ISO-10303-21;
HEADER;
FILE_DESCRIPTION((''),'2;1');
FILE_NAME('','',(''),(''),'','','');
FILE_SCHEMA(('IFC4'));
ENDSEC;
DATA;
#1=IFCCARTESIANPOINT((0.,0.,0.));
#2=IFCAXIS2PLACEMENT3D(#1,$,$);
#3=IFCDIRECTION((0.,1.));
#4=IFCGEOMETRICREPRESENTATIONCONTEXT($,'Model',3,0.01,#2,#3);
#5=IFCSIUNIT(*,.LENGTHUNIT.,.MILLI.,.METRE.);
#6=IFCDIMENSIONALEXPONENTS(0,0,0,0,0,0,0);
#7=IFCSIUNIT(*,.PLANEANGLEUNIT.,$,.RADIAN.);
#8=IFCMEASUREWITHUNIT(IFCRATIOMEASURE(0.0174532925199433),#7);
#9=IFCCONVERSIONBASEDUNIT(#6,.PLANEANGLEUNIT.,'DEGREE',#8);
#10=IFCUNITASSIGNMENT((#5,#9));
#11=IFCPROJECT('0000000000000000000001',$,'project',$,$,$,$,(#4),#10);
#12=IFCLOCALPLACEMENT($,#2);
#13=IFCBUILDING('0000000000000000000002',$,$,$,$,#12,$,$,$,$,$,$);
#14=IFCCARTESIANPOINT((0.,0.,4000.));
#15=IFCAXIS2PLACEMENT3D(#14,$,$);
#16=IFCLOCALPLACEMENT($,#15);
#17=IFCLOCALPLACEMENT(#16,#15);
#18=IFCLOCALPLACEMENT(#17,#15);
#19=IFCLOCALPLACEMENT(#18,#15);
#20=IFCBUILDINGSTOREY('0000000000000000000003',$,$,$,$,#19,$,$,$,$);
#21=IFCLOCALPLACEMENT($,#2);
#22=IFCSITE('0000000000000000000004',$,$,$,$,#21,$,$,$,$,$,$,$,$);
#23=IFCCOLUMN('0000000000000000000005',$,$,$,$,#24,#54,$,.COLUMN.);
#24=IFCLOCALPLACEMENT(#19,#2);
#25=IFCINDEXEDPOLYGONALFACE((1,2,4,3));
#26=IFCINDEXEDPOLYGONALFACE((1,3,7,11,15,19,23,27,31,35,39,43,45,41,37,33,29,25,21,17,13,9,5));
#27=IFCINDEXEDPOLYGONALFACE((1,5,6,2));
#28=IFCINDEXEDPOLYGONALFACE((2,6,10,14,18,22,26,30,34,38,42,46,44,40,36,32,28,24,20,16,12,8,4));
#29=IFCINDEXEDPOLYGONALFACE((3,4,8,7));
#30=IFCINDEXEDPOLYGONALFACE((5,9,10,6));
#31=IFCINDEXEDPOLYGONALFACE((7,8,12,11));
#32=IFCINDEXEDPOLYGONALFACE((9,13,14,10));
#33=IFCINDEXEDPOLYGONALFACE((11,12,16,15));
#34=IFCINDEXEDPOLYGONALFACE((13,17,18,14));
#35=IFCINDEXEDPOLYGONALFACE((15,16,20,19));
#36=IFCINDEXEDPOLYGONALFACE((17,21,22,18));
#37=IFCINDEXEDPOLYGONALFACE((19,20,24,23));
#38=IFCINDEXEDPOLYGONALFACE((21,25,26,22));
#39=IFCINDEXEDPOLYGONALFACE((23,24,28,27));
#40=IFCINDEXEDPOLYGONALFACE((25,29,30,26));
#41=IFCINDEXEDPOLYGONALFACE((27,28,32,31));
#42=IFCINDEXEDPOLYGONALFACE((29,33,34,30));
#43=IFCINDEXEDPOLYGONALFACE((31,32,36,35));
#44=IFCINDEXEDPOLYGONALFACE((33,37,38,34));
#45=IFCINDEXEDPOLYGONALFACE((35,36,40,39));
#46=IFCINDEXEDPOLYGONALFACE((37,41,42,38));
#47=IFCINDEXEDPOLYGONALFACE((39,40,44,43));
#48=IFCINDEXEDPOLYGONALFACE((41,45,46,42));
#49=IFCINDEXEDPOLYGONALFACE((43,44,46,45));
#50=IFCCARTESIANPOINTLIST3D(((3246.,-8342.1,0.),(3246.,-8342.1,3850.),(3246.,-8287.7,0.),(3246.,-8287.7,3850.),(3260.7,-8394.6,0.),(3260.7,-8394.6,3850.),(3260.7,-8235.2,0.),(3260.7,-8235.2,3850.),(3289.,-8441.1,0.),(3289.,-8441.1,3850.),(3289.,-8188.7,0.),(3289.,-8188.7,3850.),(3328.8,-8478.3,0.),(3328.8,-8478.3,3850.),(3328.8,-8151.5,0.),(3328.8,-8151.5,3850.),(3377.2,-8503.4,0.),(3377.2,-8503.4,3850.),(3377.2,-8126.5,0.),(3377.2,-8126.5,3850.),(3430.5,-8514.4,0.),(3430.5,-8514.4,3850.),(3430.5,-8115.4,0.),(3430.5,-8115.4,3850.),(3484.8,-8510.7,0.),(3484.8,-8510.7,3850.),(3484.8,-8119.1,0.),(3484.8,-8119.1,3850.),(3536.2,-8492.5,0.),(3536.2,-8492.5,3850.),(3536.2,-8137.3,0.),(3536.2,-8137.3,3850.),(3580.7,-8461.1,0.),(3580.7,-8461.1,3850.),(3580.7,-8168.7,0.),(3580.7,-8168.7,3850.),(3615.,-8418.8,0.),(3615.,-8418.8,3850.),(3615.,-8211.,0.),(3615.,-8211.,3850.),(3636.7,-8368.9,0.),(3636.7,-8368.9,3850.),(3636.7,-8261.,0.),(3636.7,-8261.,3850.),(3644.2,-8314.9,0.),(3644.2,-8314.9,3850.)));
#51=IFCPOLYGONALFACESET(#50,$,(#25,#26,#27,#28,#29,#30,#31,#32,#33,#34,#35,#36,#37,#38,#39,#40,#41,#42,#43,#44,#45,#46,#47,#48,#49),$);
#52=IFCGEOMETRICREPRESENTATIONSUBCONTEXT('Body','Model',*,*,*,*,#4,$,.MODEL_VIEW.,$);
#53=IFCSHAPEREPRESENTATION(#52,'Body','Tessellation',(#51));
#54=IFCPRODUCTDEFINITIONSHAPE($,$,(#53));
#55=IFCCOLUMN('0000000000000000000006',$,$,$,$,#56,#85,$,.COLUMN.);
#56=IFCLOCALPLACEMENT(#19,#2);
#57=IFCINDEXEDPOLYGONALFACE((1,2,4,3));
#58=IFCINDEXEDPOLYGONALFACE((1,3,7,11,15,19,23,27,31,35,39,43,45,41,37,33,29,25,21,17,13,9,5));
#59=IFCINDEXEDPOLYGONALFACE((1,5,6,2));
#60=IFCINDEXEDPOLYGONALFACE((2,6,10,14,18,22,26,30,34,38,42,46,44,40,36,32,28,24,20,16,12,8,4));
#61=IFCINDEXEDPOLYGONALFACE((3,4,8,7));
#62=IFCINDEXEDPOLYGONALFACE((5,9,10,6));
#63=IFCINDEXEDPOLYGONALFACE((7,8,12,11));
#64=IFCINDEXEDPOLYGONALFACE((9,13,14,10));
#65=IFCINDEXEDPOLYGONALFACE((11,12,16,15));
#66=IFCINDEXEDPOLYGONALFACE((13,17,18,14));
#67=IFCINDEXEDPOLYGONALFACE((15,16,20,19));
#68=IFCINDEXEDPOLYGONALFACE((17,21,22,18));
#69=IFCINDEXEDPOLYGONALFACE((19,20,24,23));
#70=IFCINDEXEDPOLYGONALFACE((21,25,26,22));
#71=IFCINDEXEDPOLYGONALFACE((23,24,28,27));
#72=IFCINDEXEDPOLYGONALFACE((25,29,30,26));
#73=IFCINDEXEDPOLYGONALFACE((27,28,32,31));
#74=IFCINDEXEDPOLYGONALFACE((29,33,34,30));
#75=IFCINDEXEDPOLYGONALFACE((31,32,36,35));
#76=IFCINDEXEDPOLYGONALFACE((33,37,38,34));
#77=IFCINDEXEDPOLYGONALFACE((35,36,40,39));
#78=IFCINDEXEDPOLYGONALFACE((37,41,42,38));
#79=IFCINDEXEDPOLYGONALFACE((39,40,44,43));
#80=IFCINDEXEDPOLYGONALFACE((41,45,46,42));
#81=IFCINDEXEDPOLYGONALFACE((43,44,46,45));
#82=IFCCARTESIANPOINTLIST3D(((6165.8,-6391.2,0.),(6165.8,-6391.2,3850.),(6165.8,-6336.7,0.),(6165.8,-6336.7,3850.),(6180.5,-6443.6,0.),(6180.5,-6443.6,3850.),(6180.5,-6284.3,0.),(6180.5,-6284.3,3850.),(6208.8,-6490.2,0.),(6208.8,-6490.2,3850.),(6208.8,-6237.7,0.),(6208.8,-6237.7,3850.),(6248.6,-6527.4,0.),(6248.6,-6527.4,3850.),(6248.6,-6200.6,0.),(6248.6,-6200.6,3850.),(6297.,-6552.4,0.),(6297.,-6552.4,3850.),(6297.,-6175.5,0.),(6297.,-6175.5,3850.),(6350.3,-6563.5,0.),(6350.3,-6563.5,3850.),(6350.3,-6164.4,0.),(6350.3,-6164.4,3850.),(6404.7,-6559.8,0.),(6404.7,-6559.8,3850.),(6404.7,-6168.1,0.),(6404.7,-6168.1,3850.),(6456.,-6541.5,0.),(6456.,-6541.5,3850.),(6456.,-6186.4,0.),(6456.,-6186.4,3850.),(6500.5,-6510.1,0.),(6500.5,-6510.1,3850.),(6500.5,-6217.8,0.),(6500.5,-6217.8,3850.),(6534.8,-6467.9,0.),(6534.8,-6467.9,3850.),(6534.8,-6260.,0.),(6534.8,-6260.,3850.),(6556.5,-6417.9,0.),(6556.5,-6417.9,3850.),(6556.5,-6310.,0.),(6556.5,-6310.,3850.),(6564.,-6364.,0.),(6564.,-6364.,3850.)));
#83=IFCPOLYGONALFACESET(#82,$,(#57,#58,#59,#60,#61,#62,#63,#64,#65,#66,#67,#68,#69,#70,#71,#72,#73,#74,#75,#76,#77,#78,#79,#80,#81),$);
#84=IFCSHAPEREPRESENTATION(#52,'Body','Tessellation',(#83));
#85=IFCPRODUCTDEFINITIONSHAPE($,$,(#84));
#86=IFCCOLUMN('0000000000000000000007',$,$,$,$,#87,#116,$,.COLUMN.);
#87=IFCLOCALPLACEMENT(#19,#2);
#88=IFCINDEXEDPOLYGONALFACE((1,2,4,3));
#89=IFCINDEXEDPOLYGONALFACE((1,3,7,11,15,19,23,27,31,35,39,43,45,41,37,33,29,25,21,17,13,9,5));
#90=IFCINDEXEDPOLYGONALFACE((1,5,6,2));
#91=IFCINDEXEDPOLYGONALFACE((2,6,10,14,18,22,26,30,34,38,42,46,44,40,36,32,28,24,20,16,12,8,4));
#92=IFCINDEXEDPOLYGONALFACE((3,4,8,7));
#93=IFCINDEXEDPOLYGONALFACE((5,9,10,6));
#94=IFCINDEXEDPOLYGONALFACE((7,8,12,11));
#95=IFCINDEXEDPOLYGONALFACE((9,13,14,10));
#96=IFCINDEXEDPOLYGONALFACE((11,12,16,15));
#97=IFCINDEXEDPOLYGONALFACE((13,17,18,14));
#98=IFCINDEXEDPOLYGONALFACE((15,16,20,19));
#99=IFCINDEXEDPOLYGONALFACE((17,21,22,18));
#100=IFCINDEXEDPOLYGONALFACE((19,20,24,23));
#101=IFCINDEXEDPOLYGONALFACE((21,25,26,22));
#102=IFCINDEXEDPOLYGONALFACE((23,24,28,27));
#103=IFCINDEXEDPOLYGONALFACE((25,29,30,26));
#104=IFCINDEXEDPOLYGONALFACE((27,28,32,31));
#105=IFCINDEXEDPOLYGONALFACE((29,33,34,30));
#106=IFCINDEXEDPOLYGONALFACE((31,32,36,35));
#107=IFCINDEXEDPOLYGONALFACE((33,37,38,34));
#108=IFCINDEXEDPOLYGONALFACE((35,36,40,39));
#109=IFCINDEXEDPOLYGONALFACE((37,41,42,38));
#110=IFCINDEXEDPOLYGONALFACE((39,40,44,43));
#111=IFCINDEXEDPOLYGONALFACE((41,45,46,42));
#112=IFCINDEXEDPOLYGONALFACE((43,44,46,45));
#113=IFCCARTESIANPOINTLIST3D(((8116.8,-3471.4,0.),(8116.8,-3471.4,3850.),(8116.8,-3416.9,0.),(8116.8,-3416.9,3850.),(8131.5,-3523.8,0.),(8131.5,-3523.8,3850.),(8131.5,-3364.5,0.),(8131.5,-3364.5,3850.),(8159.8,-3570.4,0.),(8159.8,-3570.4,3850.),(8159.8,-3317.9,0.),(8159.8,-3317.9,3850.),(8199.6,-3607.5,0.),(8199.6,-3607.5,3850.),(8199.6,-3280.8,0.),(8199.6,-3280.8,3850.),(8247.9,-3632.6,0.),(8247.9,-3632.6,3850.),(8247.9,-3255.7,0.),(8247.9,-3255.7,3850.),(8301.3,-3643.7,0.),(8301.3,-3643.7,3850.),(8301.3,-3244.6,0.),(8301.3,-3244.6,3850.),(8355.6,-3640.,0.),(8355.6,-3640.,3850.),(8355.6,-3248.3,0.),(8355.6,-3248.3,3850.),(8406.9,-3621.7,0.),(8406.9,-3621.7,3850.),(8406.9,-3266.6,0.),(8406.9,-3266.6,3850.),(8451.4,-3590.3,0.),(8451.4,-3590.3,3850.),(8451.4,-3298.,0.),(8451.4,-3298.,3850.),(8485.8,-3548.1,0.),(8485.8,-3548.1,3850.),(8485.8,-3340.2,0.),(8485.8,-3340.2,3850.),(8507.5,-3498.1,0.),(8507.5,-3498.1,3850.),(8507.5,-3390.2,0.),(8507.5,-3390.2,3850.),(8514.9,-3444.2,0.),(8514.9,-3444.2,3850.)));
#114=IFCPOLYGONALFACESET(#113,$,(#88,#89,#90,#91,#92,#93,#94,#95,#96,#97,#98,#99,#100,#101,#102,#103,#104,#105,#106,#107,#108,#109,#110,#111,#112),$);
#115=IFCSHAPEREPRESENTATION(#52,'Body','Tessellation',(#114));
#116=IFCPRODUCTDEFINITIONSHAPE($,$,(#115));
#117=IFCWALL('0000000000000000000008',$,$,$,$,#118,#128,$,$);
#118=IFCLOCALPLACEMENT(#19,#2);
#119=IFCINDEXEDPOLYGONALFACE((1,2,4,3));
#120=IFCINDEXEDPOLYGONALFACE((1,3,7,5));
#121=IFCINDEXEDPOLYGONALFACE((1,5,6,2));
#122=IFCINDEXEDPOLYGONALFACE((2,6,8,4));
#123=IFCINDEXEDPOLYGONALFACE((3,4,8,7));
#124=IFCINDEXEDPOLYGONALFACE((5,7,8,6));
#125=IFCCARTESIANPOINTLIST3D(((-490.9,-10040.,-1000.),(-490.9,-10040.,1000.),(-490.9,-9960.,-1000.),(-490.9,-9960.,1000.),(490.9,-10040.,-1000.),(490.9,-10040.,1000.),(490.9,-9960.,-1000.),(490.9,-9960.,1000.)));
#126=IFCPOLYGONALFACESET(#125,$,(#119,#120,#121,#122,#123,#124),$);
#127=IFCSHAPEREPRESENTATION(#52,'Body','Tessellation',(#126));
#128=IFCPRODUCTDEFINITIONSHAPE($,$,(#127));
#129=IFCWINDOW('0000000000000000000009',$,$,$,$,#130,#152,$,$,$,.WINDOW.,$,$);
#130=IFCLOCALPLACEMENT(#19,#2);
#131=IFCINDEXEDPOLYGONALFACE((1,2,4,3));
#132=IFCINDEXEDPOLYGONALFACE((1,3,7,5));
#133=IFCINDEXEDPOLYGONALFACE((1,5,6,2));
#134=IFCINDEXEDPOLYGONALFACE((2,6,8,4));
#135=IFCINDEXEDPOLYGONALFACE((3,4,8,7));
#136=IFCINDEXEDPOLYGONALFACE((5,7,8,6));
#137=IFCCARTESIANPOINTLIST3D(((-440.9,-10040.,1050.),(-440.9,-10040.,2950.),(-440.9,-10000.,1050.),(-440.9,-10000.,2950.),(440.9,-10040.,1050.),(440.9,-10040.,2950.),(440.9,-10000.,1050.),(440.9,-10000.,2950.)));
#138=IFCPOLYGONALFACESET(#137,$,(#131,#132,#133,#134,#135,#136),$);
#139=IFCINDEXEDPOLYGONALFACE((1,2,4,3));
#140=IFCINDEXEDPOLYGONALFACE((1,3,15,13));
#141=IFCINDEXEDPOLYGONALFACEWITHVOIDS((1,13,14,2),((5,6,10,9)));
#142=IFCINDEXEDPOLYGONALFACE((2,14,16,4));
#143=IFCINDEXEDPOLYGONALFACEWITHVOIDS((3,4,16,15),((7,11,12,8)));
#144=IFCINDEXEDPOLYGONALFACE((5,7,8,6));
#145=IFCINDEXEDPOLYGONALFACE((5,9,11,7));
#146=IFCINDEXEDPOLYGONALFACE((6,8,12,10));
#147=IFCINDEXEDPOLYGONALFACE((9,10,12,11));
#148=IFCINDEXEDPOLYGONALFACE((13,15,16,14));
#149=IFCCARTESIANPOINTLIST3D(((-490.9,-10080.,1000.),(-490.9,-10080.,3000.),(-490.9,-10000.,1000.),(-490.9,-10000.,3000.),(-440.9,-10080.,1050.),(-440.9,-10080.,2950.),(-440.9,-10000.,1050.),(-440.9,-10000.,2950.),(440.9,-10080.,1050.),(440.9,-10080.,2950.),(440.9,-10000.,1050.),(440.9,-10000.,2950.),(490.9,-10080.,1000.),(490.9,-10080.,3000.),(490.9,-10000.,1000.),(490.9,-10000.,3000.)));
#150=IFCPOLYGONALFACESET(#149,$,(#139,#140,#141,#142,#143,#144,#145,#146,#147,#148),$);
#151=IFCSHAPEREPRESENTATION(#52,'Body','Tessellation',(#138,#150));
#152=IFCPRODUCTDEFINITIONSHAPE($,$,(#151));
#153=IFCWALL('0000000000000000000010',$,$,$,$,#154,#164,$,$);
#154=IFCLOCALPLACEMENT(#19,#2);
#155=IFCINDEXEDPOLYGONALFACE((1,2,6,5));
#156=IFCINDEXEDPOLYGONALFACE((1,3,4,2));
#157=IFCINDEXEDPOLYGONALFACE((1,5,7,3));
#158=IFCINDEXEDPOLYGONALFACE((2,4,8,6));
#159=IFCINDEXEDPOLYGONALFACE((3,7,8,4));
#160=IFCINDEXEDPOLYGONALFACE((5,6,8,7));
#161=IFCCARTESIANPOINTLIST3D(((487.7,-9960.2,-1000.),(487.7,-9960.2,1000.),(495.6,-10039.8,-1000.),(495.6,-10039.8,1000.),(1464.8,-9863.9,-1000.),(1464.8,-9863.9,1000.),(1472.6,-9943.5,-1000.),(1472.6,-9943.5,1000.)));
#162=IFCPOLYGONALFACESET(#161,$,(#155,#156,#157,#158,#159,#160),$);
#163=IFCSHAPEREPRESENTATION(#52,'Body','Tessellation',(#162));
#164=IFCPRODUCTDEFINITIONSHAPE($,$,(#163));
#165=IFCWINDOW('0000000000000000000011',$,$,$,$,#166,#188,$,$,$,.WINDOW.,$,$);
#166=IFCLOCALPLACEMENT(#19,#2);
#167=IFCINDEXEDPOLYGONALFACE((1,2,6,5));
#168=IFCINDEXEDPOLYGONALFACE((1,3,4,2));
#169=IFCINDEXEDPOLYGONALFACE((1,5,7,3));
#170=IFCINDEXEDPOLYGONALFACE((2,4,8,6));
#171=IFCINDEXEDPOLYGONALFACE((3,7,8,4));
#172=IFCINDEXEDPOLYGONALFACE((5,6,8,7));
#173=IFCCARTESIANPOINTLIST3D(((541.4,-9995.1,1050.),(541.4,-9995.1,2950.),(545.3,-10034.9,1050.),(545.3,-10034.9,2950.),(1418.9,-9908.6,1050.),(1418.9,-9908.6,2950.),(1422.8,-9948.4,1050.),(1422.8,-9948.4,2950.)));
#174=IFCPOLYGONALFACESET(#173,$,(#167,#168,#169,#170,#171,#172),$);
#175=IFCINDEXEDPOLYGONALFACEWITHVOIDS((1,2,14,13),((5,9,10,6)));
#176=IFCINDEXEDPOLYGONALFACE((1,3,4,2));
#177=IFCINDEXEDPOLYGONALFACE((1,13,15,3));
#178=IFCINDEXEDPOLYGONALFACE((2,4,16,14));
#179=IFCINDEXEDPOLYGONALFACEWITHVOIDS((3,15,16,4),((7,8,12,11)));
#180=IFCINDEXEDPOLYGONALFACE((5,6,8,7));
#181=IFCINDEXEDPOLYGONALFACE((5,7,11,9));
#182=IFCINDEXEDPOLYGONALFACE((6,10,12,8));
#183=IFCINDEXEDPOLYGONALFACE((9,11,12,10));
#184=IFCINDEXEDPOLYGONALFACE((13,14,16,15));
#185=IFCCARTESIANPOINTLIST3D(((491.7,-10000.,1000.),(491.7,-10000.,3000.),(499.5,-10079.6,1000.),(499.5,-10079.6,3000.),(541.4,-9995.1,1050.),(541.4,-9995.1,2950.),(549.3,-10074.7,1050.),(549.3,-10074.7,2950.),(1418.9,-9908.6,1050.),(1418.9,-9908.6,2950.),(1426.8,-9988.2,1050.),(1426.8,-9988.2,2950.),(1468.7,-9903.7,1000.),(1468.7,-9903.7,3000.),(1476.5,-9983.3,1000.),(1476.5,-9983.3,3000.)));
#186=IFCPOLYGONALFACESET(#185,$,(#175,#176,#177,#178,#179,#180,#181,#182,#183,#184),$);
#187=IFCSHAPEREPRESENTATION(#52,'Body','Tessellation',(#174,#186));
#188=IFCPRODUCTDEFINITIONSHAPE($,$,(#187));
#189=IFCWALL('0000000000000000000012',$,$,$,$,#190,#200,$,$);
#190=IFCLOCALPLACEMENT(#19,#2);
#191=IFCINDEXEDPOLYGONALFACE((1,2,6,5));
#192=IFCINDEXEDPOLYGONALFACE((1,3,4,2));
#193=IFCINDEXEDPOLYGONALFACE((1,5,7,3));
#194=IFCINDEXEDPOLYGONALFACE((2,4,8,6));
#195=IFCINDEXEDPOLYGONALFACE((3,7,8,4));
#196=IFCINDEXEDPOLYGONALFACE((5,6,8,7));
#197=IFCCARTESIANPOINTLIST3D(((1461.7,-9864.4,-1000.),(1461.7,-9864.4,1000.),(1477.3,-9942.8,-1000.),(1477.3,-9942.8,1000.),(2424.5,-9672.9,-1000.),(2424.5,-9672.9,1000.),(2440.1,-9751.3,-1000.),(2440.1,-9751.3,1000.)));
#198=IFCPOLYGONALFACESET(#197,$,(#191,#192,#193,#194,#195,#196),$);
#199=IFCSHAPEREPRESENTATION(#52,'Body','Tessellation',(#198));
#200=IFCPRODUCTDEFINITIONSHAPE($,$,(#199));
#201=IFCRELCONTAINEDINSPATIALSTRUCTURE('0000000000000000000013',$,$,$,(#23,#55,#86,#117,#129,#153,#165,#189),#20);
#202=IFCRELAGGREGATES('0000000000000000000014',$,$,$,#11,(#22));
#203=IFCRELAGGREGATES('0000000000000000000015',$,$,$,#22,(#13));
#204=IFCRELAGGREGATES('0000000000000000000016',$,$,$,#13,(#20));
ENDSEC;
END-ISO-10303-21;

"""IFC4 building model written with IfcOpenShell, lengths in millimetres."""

from ifc_helpers import new_model, entity, si_unit, converted_unit, direction, frame, origin, origin_2d, place, context, subcontext, project, spatial, rectangle, circle, extrude, element, save


model = new_model("IFC4")

# Units and contexts
model_context = context("Model", 3, precision=0.01, world=origin(), true_north=direction((0.0, 1.0)))
body_context = subcontext(model_context, "Body", "Model", "MODEL_VIEW")
ifc_project = project(units=[si_unit("LENGTHUNIT", "METRE", prefix="MILLI"), converted_unit("PLANEANGLEUNIT", "DEGREE", entity("IfcRatioMeasure", 0.0174532925199433), si_unit("PLANEANGLEUNIT", "RADIAN"), dimensions=[0, 0, 0, 0, 0, 0, 0])], contexts=[model_context])

# Site, building, storey
site_placement = place(None, origin())
site = spatial("IfcSite", under=ifc_project, at=site_placement)
building_placement = place(None, origin())
building = spatial("IfcBuilding", under=site, at=building_placement)
placement_1 = place(None, frame((0.0, 0.0, 4000.0)))
placement_2 = place(placement_1, frame((0.0, 0.0, 4000.0)))
placement_3 = place(placement_2, frame((0.0, 0.0, 4000.0)))
storey_placement = place(placement_3, frame((0.0, 0.0, 4000.0)))
storey = spatial("IfcBuildingStorey", under=building, at=storey_placement)

# Columns
for number, where in (
    (1, (3444.2, -8314.9, 0.0)),
    (2, (6364.0, -6364.0, 0.0)),
    (3, (8314.9, -3444.2, 0.0)),
):
    element("IfcColumn", number, at=place(storey_placement, frame(where)), inside=storey, PredefinedType="COLUMN", context=body_context, shape_type="SweptSolid", body=[
        extrude(circle(Radius=200.0, at=origin_2d()), origin(), (0.0, 0.0, 1.0), 3850.0),
    ])

# Wall
wall_1_placement = place(storey_placement, frame((0.0, -10000.0, -1000.0), z_axis=(0.0, 0.0, 1.0), x_axis=(10000.0, 0.000119, 0.0)))
element("IfcWall", 4, at=wall_1_placement, inside=storey, context=body_context, shape_type="SweptSolid", body=[
    extrude(rectangle(XDim=981.7, YDim=80.0, at=origin_2d()), origin(), (0.0, 0.0, 1.0), 2000.0),
])

# Window
cartesian_point_1 = entity("IfcCartesianPoint", [-440.9, -950.0])
shared_polyline = entity("IfcPolyline", [cartesian_point_1, entity("IfcCartesianPoint", [-440.9, 950.0]), entity("IfcCartesianPoint", [-440.9, 950.0]), entity("IfcCartesianPoint", [440.9, 950.0]), entity("IfcCartesianPoint", [440.9, 950.0]), entity("IfcCartesianPoint", [440.9, -950.0]), entity("IfcCartesianPoint", [440.9, -950.0]), entity("IfcCartesianPoint", [-440.9, -950.0]), cartesian_point_1])
window_1_placement = place(storey_placement, frame((0.0, -10000.0, 2000.0), z_axis=(0.0, 0.0, 1.0), x_axis=(10000.0, 0.000119, 0.0)))
cartesian_point_2 = entity("IfcCartesianPoint", [-490.9, -1000.0])
element("IfcWindow", 5, at=window_1_placement, inside=storey, PredefinedType="WINDOW", context=body_context, shape_type="SweptSolid", body=[
    entity("IfcExtrudedAreaSolid", entity("IfcArbitraryClosedProfileDef", "AREA", None, shared_polyline), entity("IfcAxis2Placement3D", entity("IfcCartesianPoint", [0.0, 0.0, 0.0]), entity("IfcDirection", [0.0, -1.0, 0.0]), entity("IfcDirection", [1.0, 0.0, 0.0])), entity("IfcDirection", [0.0, 0.0, 1.0]), 40.0),
    entity("IfcExtrudedAreaSolid", entity("IfcArbitraryProfileDefWithVoids", "AREA", None, entity("IfcPolyline", [cartesian_point_2, entity("IfcCartesianPoint", [-490.9, 1000.0]), entity("IfcCartesianPoint", [-490.9, 1000.0]), entity("IfcCartesianPoint", [490.9, 1000.0]), entity("IfcCartesianPoint", [490.9, 1000.0]), entity("IfcCartesianPoint", [490.9, -1000.0]), entity("IfcCartesianPoint", [490.9, -1000.0]), entity("IfcCartesianPoint", [-490.9, -1000.0]), cartesian_point_2]), [shared_polyline]), entity("IfcAxis2Placement3D", entity("IfcCartesianPoint", [0.0, 0.0, 0.0]), entity("IfcDirection", [0.0, -1.0, 0.0]), entity("IfcDirection", [1.0, 0.0, 0.0])), entity("IfcDirection", [0.0, 0.0, 1.0]), 80.0),
])

# Wall
wall_2_placement = place(storey_placement, frame((980.2, -9951.8, -1000.0), z_axis=(0.0, 0.0, 1.0), x_axis=(9951.84745, 980.169547, 0.0)))
element("IfcWall", 6, at=wall_2_placement, inside=storey, context=body_context, shape_type="SweptSolid", body=[
    extrude(rectangle(XDim=981.7, YDim=80.0, at=origin_2d()), origin(), (0.0, 0.0, 1.0), 2000.0),
])

# Window
window_2_placement = place(storey_placement, frame((980.2, -9951.8, 2000.0), z_axis=(0.0, 0.0, 1.0), x_axis=(9951.84745, 980.169547, 0.0)))
cartesian_point_3 = entity("IfcCartesianPoint", [-490.9, -1000.0])
element("IfcWindow", 7, at=window_2_placement, inside=storey, PredefinedType="WINDOW", context=body_context, shape_type="SweptSolid", body=[
    entity("IfcExtrudedAreaSolid", entity("IfcArbitraryClosedProfileDef", "AREA", None, shared_polyline), entity("IfcAxis2Placement3D", entity("IfcCartesianPoint", [0.0, 0.0, 0.0]), entity("IfcDirection", [0.0, -1.0, 0.0]), entity("IfcDirection", [1.0, 0.0, 0.0])), entity("IfcDirection", [0.0, 0.0, 1.0]), 40.0),
    entity("IfcExtrudedAreaSolid", entity("IfcArbitraryProfileDefWithVoids", "AREA", None, entity("IfcPolyline", [cartesian_point_3, entity("IfcCartesianPoint", [-490.9, 1000.0]), entity("IfcCartesianPoint", [-490.9, 1000.0]), entity("IfcCartesianPoint", [490.9, 1000.0]), entity("IfcCartesianPoint", [490.9, 1000.0]), entity("IfcCartesianPoint", [490.9, -1000.0]), entity("IfcCartesianPoint", [490.9, -1000.0]), entity("IfcCartesianPoint", [-490.9, -1000.0]), cartesian_point_3]), [shared_polyline]), entity("IfcAxis2Placement3D", entity("IfcCartesianPoint", [0.0, 0.0, 0.0]), entity("IfcDirection", [0.0, -1.0, 0.0]), entity("IfcDirection", [1.0, 0.0, 0.0])), entity("IfcDirection", [0.0, 0.0, 1.0]), 80.0),
])

# Wall
wall_3_placement = place(storey_placement, frame((1950.9, -9807.9, -1000.0), z_axis=(0.0, 0.0, 1.0), x_axis=(9807.852625, 1950.904121, 0.0)))
element("IfcWall", 8, at=wall_3_placement, inside=storey, context=body_context, shape_type="SweptSolid", body=[
    extrude(rectangle(XDim=981.7, YDim=80.0, at=origin_2d()), origin(), (0.0, 0.0, 1.0), 2000.0),
])

save(model, "model.ifc")
